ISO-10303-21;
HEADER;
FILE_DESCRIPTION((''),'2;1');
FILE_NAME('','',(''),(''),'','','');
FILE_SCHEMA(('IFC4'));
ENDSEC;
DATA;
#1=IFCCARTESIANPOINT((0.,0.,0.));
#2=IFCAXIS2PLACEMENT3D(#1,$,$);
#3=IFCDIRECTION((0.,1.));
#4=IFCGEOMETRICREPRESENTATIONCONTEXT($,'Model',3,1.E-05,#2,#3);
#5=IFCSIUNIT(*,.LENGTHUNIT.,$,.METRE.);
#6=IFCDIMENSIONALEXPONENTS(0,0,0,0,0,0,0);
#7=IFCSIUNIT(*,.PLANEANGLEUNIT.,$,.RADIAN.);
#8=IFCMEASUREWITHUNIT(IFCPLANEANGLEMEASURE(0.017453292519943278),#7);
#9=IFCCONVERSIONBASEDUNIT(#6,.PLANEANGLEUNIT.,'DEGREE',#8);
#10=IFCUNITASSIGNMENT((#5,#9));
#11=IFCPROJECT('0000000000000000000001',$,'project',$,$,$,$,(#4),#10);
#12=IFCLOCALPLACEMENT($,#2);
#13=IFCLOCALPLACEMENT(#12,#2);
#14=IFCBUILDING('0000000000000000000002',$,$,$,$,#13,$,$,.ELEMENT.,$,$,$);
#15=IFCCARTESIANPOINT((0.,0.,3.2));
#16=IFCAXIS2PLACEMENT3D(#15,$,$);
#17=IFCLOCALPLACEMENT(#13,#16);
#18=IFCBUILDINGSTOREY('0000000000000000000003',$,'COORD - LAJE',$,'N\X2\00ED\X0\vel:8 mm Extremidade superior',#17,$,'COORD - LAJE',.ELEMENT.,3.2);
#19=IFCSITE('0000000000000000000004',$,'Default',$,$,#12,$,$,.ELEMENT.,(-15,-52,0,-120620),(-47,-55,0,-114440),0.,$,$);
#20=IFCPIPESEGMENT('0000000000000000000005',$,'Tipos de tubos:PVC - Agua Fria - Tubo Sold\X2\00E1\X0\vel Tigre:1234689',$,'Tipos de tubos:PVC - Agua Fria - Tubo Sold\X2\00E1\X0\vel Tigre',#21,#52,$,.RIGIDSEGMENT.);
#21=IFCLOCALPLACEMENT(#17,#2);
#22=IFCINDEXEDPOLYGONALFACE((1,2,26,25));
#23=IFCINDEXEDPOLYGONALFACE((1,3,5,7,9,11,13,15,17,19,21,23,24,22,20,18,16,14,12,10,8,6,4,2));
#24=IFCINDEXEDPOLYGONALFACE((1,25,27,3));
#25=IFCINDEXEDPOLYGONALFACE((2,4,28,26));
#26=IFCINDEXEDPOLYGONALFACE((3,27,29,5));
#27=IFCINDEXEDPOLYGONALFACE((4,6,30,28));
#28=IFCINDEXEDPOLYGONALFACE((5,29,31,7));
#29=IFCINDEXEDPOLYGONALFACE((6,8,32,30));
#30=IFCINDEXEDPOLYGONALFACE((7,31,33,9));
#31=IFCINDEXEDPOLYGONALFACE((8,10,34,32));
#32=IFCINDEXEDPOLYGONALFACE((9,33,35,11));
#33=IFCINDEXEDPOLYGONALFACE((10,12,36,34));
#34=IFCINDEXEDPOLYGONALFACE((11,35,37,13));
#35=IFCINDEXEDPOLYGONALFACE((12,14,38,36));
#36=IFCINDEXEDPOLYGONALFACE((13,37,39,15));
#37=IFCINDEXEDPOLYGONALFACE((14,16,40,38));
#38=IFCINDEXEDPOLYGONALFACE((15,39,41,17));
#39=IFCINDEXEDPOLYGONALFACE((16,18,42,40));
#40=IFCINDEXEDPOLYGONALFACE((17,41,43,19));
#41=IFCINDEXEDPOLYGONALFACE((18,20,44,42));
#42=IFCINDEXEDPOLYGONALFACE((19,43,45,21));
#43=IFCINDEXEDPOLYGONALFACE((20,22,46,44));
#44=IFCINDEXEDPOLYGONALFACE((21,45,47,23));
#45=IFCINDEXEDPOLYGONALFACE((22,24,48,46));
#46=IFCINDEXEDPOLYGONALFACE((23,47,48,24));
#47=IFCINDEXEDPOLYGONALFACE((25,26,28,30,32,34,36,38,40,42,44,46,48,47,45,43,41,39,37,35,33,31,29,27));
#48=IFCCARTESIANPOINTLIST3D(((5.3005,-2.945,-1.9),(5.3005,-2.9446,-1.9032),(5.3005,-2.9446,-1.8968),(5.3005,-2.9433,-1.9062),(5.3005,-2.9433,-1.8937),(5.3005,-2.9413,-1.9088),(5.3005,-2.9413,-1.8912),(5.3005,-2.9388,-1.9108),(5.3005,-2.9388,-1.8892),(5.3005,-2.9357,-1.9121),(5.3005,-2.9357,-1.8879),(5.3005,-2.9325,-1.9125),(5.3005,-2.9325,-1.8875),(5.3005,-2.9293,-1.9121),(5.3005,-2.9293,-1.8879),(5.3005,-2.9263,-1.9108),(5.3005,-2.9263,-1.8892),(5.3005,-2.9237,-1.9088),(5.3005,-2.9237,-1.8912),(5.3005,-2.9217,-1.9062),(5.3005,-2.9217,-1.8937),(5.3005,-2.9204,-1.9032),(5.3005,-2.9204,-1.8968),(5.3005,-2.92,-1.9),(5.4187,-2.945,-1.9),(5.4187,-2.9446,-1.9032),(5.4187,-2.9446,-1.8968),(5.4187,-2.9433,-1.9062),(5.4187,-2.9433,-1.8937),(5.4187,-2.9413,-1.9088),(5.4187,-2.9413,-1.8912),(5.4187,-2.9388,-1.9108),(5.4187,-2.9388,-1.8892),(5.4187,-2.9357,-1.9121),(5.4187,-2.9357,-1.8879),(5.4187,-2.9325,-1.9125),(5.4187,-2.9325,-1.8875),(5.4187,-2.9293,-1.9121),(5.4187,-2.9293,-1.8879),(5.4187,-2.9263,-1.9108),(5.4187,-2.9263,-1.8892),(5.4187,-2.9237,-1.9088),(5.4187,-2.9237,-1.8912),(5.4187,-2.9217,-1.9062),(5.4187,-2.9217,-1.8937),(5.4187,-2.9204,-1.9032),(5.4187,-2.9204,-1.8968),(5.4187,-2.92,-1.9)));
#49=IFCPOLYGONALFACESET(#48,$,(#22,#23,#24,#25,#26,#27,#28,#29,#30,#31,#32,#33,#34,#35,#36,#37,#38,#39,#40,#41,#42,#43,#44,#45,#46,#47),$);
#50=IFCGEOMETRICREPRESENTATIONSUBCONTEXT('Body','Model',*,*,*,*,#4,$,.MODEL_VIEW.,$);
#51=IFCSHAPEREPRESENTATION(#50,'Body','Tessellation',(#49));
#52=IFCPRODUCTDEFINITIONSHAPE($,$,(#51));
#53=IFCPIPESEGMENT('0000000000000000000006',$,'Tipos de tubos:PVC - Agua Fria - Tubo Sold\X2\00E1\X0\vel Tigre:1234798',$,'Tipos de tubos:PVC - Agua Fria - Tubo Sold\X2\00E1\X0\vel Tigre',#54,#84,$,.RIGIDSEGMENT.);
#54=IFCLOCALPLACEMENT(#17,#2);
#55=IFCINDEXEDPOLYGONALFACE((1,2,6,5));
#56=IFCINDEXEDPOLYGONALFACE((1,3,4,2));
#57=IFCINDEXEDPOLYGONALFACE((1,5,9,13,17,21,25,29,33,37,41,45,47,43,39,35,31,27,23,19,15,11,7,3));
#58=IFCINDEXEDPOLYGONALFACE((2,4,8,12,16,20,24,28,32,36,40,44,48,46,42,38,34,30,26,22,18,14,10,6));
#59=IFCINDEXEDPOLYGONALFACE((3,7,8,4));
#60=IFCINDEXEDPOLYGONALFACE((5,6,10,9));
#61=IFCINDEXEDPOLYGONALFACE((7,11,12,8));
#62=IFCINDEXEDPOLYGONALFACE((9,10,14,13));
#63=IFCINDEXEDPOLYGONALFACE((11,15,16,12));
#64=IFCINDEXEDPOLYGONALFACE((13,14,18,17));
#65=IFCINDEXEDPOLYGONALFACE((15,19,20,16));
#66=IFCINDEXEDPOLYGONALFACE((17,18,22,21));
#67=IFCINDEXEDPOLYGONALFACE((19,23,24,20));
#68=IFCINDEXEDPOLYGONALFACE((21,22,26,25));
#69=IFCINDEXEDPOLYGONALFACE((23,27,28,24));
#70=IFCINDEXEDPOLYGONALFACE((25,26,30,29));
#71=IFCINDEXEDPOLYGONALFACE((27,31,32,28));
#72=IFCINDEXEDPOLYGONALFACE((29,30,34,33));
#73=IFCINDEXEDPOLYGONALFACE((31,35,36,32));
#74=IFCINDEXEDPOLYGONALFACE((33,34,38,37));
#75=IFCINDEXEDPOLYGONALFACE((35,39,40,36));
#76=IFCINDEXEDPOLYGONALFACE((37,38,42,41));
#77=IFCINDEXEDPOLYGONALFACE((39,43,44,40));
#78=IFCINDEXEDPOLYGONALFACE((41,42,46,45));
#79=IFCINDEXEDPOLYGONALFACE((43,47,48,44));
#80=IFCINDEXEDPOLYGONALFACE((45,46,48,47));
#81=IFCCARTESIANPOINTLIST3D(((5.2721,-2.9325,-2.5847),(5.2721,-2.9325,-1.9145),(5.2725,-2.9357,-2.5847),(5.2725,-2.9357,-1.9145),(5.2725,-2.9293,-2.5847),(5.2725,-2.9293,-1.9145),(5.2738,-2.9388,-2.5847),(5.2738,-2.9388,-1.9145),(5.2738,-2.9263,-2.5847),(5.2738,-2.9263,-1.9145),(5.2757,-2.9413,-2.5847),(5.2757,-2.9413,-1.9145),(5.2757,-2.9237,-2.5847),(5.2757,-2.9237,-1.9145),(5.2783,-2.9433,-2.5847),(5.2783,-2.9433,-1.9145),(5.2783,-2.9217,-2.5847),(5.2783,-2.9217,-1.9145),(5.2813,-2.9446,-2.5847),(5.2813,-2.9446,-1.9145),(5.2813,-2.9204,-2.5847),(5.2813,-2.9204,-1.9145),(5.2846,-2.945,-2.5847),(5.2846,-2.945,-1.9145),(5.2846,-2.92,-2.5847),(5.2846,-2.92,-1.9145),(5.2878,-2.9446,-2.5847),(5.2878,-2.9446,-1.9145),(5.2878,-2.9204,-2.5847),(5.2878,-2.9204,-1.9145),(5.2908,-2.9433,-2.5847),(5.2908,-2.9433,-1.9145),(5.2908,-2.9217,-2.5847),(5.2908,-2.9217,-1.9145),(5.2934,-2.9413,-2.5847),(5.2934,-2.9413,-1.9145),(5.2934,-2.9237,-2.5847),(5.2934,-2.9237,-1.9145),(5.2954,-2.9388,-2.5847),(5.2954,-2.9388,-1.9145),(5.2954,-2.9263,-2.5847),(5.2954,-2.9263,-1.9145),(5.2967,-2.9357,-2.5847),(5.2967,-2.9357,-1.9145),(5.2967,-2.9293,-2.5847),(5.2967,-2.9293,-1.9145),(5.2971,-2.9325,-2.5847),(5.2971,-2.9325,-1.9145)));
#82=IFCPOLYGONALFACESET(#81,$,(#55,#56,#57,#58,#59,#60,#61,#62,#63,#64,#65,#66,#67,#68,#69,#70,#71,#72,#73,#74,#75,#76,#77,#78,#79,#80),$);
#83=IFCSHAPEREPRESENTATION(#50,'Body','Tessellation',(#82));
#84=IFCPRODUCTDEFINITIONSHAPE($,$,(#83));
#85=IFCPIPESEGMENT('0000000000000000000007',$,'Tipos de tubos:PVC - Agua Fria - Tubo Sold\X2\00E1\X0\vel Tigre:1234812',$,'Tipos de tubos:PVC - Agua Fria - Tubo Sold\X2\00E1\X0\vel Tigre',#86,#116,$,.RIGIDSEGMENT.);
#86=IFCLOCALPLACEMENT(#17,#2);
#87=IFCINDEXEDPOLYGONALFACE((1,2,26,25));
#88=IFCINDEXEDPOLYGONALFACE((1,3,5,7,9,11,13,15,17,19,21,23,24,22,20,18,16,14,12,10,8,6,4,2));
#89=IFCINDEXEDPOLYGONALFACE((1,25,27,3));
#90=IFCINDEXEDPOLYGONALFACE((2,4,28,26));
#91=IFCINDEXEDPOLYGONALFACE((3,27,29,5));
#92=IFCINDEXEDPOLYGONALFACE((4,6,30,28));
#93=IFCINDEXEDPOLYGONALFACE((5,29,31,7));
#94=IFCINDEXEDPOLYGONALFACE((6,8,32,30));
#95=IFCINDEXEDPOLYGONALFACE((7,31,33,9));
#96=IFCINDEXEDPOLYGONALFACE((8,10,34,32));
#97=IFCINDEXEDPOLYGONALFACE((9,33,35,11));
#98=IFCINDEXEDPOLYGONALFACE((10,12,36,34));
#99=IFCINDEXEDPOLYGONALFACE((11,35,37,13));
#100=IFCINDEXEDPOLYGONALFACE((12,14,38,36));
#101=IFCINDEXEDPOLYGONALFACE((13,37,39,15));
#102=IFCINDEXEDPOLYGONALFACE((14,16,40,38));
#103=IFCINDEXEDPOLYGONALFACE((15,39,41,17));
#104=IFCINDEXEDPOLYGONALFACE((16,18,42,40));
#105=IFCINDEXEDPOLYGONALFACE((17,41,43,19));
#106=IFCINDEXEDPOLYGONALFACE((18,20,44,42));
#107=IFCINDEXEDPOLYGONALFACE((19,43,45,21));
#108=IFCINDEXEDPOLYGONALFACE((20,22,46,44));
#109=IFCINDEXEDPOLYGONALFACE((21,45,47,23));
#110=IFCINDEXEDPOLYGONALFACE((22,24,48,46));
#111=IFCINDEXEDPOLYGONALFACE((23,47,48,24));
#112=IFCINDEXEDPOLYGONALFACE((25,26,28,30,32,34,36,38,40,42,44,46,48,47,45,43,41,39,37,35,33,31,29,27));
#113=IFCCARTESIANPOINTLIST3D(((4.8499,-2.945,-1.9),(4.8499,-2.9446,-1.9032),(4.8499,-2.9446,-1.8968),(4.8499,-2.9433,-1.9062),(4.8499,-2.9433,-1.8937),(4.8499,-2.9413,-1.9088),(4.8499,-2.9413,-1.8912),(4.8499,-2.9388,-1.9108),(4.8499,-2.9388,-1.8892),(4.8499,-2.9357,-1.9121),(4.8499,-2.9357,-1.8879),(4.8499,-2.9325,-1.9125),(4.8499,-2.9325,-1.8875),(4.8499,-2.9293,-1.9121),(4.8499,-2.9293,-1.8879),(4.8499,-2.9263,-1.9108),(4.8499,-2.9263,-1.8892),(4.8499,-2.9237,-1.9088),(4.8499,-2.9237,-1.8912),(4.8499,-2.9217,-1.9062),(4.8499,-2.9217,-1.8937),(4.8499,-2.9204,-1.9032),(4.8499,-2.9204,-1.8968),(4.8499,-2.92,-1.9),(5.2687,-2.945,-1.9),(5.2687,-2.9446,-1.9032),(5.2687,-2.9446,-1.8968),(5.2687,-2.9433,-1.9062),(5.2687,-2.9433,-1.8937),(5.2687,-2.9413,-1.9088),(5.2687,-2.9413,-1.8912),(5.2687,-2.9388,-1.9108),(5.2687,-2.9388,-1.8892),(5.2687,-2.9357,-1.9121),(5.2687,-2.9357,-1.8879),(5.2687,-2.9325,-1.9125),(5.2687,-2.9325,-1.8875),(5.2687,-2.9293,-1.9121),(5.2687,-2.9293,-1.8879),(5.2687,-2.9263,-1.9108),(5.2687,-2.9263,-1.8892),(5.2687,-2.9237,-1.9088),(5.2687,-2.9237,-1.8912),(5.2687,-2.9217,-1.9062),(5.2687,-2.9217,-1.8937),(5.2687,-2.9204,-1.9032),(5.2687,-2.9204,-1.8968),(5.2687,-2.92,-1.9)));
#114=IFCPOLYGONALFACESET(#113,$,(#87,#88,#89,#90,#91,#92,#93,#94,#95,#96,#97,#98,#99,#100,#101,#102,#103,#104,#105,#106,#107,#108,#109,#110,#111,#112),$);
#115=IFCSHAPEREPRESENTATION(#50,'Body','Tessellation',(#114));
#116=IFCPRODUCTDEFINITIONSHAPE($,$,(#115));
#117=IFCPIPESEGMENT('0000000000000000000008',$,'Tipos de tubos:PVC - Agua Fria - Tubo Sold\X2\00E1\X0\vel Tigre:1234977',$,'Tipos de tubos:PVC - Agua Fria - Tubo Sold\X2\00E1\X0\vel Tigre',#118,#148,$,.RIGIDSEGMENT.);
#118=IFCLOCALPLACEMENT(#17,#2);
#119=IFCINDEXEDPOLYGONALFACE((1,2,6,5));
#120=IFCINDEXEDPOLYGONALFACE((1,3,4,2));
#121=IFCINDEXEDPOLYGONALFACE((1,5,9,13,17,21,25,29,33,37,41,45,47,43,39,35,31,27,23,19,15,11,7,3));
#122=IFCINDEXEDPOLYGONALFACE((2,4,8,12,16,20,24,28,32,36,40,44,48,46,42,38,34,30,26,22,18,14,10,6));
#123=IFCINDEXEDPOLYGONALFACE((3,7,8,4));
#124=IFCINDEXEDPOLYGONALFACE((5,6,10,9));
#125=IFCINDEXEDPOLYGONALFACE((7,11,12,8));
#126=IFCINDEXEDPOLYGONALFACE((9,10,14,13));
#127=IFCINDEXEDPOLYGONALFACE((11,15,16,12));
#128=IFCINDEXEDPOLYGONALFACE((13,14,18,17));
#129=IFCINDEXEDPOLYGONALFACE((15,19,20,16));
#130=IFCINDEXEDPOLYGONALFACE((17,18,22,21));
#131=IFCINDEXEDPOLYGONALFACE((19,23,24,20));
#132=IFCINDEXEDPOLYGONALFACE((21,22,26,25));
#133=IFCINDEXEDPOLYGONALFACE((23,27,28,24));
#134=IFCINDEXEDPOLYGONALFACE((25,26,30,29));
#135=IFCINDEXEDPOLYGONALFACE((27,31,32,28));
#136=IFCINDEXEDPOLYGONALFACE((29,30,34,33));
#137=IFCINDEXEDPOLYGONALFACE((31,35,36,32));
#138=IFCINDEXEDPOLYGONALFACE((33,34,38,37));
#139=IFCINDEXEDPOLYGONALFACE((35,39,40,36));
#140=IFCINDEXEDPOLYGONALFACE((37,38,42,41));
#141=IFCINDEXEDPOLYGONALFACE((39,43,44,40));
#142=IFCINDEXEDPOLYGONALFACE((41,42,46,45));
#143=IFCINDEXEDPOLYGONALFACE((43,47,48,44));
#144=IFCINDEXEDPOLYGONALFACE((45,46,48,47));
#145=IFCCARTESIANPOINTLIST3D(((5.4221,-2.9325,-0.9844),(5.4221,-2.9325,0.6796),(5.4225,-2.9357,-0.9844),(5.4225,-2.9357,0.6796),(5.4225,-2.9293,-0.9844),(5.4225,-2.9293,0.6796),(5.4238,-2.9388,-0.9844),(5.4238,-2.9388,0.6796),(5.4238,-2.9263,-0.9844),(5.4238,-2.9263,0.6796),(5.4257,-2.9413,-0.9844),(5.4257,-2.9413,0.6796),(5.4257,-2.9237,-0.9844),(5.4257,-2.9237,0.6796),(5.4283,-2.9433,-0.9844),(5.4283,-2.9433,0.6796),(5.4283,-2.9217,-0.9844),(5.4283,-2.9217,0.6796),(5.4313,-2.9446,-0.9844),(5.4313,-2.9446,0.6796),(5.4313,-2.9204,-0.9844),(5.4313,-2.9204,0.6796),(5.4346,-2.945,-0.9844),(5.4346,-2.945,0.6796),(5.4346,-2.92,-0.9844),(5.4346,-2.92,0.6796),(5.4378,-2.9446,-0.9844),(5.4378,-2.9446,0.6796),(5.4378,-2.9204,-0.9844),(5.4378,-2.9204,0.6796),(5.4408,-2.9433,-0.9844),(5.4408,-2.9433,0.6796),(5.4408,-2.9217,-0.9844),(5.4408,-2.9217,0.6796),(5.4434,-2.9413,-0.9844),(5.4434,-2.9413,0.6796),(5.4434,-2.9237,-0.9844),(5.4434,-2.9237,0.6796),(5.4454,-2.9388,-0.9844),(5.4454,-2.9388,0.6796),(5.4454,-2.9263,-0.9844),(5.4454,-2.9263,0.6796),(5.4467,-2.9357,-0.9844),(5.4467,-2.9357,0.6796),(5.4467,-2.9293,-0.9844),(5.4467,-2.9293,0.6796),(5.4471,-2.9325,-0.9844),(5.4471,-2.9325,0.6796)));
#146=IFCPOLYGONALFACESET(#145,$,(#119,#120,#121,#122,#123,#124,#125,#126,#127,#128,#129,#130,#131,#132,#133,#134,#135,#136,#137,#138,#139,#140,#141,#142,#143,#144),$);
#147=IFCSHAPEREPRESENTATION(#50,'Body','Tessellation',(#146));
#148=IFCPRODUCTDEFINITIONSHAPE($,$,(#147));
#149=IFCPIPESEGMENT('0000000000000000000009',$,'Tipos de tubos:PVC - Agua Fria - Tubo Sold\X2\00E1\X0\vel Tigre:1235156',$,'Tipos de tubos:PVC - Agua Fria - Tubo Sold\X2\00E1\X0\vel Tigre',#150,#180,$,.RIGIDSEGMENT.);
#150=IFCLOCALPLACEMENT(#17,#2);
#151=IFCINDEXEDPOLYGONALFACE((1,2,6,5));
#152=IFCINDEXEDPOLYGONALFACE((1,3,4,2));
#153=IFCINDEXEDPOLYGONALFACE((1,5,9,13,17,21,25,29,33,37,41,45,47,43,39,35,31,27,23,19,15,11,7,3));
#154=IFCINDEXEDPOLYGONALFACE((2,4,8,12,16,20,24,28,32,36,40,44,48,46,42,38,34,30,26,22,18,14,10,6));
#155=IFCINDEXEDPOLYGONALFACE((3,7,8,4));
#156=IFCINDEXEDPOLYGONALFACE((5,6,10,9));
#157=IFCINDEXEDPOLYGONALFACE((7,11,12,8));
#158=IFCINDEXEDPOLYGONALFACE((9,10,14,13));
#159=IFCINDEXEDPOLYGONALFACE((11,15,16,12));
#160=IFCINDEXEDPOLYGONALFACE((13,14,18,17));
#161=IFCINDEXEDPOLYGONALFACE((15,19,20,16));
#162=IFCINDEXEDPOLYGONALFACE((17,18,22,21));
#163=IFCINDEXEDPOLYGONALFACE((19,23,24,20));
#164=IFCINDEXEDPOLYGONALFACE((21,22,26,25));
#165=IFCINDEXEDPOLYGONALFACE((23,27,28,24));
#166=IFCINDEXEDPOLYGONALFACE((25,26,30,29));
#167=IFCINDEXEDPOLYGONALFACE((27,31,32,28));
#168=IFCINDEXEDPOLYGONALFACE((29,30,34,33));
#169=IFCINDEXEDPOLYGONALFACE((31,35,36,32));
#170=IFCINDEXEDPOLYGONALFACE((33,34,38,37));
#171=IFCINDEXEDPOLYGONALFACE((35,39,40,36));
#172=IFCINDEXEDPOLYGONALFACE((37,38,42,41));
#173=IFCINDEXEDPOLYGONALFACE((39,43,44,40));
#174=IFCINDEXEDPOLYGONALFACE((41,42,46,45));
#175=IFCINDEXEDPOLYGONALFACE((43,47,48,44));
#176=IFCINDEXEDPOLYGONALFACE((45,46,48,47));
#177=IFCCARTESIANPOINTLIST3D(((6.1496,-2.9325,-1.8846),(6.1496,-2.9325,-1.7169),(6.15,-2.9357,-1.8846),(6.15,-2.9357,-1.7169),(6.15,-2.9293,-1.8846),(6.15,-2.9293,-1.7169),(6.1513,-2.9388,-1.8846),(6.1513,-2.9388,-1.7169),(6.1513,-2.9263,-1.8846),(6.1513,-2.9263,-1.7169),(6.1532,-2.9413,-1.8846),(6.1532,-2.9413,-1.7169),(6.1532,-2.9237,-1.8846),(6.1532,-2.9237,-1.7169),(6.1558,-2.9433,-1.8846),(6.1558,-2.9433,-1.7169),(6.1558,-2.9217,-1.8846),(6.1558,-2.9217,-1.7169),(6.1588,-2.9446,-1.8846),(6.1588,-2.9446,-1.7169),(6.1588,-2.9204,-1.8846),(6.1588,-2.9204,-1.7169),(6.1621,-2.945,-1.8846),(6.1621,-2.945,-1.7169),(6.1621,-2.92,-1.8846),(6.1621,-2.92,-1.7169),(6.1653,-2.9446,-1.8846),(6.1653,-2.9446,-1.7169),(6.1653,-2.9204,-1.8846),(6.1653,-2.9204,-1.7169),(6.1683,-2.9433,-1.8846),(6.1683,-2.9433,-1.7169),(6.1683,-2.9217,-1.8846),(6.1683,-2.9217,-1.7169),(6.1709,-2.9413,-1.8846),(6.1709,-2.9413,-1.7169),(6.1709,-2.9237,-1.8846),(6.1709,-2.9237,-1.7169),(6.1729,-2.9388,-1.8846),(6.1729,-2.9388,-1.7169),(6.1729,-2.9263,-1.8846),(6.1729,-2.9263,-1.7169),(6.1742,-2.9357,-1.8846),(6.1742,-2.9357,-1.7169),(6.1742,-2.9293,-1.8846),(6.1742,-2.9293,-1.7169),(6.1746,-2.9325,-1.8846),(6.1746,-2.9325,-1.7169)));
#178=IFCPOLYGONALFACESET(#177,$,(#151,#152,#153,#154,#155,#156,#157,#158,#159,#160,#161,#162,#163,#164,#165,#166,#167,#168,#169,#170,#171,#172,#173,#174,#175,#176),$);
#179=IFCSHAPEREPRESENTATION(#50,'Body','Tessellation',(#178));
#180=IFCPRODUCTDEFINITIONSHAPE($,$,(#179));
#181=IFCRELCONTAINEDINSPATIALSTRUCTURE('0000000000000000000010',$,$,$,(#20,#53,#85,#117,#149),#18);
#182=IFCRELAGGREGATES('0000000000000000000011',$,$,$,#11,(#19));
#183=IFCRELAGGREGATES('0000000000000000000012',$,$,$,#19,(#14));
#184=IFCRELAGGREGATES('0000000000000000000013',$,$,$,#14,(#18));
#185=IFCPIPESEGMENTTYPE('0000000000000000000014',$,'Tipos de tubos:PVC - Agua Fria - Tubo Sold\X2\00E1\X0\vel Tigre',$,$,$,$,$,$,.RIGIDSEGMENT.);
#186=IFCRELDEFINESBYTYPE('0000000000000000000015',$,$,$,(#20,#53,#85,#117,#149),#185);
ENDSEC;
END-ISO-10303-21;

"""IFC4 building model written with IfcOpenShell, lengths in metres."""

from ifc_helpers import new_model, entity, si_unit, converted_unit, direction, frame, origin, place, context, subcontext, project, spatial, arc, indexed_curve, outline, extrude, type_object, element, save


model = new_model("IFC4")

# Units and contexts
model_context = context("Model", 3, precision=1e-05, world=origin(), true_north=direction((0.0, 1.0)))
body_context = subcontext(model_context, "Body", "Model", "MODEL_VIEW")
ifc_project = project(units=[si_unit("LENGTHUNIT", "METRE"), converted_unit("PLANEANGLEUNIT", "DEGREE", entity("IfcPlaneAngleMeasure", 0.017453292519943278), si_unit("PLANEANGLEUNIT", "RADIAN"), dimensions=[0, 0, 0, 0, 0, 0, 0])], contexts=[model_context])

# Site, building, storey
site_placement = place(None, origin())
site = spatial("IfcSite", under=ifc_project, at=site_placement, Name="Default", CompositionType="ELEMENT", RefLatitude=(-15, -52, 0, -120620), RefLongitude=(-47, -55, 0, -114440), RefElevation=0.0)
building_placement = place(site_placement, origin())
building = spatial("IfcBuilding", under=site, at=building_placement, CompositionType="ELEMENT")
storey_placement = place(building_placement, frame((0.0, 0.0, 3.2)))
storey = spatial("IfcBuildingStorey", under=building, at=storey_placement, Name="COORD - LAJE", ObjectType="Nível:8 mm Extremidade superior", LongName="COORD - LAJE", CompositionType="ELEMENT", Elevation=3.2)

# Pipe segments
pipe_segment_type = type_object("IfcPipeSegmentType", Name="Tipos de tubos:PVC - Agua Fria - Tubo Soldável Tigre", PredefinedType="RIGIDSEGMENT")
pipe_segment_1_placement = place(storey_placement, origin())
element("IfcPipeSegment", 1, at=pipe_segment_1_placement, inside=storey, type_object=pipe_segment_type, Name="Tipos de tubos:PVC - Agua Fria - Tubo Soldável Tigre:1234689", ObjectType="Tipos de tubos:PVC - Agua Fria - Tubo Soldável Tigre", PredefinedType="RIGIDSEGMENT", context=body_context, shape_type="SweptSolid", body=[
    extrude(outline(indexed_curve([(0.0125, 0.0), (0.0088, 0.0088), (0.0, 0.0125), (-0.0088, 0.0088), (-0.0125, 0.0), (-0.0088, -0.0088), (0.0, -0.0125), (0.0088, -0.0088)], segments=[arc(1, 2, 3), arc(3, 4, 5), arc(5, 6, 7), arc(7, 8, 1)], self_intersect=False)), frame((5.3005, -2.9325, -1.9), z_axis=(1.0, 0.0, 0.0), x_axis=(0.0, -1.0, 0.0)), (0.0, 0.0, 1.0), 0.1182),
])
pipe_segment_2_placement = place(storey_placement, origin())
element("IfcPipeSegment", 2, at=pipe_segment_2_placement, inside=storey, type_object=pipe_segment_type, Name="Tipos de tubos:PVC - Agua Fria - Tubo Soldável Tigre:1234798", ObjectType="Tipos de tubos:PVC - Agua Fria - Tubo Soldável Tigre", PredefinedType="RIGIDSEGMENT", context=body_context, shape_type="SweptSolid", body=[
    extrude(outline(indexed_curve([(0.0125, 0.0), (0.0088, 0.0088), (0.0, 0.0125), (-0.0088, 0.0088), (-0.0125, 0.0), (-0.0088, -0.0088), (0.0, -0.0125), (0.0088, -0.0088)], segments=[arc(1, 2, 3), arc(3, 4, 5), arc(5, 6, 7), arc(7, 8, 1)], self_intersect=False)), frame((5.2846, -2.9325, -2.5847), z_axis=(0.0, 0.0, 1.0), x_axis=(-1.0, 0.0, 0.0)), (0.0, 0.0, 1.0), 0.6702),
])
pipe_segment_3_placement = place(storey_placement, origin())
element("IfcPipeSegment", 3, at=pipe_segment_3_placement, inside=storey, type_object=pipe_segment_type, Name="Tipos de tubos:PVC - Agua Fria - Tubo Soldável Tigre:1234812", ObjectType="Tipos de tubos:PVC - Agua Fria - Tubo Soldável Tigre", PredefinedType="RIGIDSEGMENT", context=body_context, shape_type="SweptSolid", body=[
    extrude(outline(indexed_curve([(0.0125, 0.0), (0.0088, 0.0088), (0.0, 0.0125), (-0.0088, 0.0088), (-0.0125, 0.0), (-0.0088, -0.0088), (0.0, -0.0125), (0.0088, -0.0088)], segments=[arc(1, 2, 3), arc(3, 4, 5), arc(5, 6, 7), arc(7, 8, 1)], self_intersect=False)), frame((4.8499, -2.9325, -1.9), z_axis=(1.0, 0.0, 0.0), x_axis=(0.0, 1.0, 0.0)), (0.0, 0.0, 1.0), 0.4188),
])
pipe_segment_4_placement = place(storey_placement, origin())
element("IfcPipeSegment", 4, at=pipe_segment_4_placement, inside=storey, type_object=pipe_segment_type, Name="Tipos de tubos:PVC - Agua Fria - Tubo Soldável Tigre:1234977", ObjectType="Tipos de tubos:PVC - Agua Fria - Tubo Soldável Tigre", PredefinedType="RIGIDSEGMENT", context=body_context, shape_type="SweptSolid", body=[
    extrude(outline(indexed_curve([(0.0125, 0.0), (0.0088, 0.0088), (0.0, 0.0125), (-0.0088, 0.0088), (-0.0125, 0.0), (-0.0088, -0.0088), (0.0, -0.0125), (0.0088, -0.0088)], segments=[arc(1, 2, 3), arc(3, 4, 5), arc(5, 6, 7), arc(7, 8, 1)], self_intersect=False)), frame((5.4346, -2.9325, -0.9844)), (0.0, 0.0, 1.0), 1.664),
])
pipe_segment_5_placement = place(storey_placement, origin())
element("IfcPipeSegment", 5, at=pipe_segment_5_placement, inside=storey, type_object=pipe_segment_type, Name="Tipos de tubos:PVC - Agua Fria - Tubo Soldável Tigre:1235156", ObjectType="Tipos de tubos:PVC - Agua Fria - Tubo Soldável Tigre", PredefinedType="RIGIDSEGMENT", context=body_context, shape_type="SweptSolid", body=[
    extrude(outline(indexed_curve([(0.0125, 0.0), (0.0088, 0.0088), (0.0, 0.0125), (-0.0088, 0.0088), (-0.0125, 0.0), (-0.0088, -0.0088), (0.0, -0.0125), (0.0088, -0.0088)], segments=[arc(1, 2, 3), arc(3, 4, 5), arc(5, 6, 7), arc(7, 8, 1)], self_intersect=False)), frame((6.1621, -2.9325, -1.8846), z_axis=(0.0, 0.0, 1.0), x_axis=(-1.0, 0.0, 0.0)), (0.0, 0.0, 1.0), 0.1677),
])

save(model, "model.ifc")
